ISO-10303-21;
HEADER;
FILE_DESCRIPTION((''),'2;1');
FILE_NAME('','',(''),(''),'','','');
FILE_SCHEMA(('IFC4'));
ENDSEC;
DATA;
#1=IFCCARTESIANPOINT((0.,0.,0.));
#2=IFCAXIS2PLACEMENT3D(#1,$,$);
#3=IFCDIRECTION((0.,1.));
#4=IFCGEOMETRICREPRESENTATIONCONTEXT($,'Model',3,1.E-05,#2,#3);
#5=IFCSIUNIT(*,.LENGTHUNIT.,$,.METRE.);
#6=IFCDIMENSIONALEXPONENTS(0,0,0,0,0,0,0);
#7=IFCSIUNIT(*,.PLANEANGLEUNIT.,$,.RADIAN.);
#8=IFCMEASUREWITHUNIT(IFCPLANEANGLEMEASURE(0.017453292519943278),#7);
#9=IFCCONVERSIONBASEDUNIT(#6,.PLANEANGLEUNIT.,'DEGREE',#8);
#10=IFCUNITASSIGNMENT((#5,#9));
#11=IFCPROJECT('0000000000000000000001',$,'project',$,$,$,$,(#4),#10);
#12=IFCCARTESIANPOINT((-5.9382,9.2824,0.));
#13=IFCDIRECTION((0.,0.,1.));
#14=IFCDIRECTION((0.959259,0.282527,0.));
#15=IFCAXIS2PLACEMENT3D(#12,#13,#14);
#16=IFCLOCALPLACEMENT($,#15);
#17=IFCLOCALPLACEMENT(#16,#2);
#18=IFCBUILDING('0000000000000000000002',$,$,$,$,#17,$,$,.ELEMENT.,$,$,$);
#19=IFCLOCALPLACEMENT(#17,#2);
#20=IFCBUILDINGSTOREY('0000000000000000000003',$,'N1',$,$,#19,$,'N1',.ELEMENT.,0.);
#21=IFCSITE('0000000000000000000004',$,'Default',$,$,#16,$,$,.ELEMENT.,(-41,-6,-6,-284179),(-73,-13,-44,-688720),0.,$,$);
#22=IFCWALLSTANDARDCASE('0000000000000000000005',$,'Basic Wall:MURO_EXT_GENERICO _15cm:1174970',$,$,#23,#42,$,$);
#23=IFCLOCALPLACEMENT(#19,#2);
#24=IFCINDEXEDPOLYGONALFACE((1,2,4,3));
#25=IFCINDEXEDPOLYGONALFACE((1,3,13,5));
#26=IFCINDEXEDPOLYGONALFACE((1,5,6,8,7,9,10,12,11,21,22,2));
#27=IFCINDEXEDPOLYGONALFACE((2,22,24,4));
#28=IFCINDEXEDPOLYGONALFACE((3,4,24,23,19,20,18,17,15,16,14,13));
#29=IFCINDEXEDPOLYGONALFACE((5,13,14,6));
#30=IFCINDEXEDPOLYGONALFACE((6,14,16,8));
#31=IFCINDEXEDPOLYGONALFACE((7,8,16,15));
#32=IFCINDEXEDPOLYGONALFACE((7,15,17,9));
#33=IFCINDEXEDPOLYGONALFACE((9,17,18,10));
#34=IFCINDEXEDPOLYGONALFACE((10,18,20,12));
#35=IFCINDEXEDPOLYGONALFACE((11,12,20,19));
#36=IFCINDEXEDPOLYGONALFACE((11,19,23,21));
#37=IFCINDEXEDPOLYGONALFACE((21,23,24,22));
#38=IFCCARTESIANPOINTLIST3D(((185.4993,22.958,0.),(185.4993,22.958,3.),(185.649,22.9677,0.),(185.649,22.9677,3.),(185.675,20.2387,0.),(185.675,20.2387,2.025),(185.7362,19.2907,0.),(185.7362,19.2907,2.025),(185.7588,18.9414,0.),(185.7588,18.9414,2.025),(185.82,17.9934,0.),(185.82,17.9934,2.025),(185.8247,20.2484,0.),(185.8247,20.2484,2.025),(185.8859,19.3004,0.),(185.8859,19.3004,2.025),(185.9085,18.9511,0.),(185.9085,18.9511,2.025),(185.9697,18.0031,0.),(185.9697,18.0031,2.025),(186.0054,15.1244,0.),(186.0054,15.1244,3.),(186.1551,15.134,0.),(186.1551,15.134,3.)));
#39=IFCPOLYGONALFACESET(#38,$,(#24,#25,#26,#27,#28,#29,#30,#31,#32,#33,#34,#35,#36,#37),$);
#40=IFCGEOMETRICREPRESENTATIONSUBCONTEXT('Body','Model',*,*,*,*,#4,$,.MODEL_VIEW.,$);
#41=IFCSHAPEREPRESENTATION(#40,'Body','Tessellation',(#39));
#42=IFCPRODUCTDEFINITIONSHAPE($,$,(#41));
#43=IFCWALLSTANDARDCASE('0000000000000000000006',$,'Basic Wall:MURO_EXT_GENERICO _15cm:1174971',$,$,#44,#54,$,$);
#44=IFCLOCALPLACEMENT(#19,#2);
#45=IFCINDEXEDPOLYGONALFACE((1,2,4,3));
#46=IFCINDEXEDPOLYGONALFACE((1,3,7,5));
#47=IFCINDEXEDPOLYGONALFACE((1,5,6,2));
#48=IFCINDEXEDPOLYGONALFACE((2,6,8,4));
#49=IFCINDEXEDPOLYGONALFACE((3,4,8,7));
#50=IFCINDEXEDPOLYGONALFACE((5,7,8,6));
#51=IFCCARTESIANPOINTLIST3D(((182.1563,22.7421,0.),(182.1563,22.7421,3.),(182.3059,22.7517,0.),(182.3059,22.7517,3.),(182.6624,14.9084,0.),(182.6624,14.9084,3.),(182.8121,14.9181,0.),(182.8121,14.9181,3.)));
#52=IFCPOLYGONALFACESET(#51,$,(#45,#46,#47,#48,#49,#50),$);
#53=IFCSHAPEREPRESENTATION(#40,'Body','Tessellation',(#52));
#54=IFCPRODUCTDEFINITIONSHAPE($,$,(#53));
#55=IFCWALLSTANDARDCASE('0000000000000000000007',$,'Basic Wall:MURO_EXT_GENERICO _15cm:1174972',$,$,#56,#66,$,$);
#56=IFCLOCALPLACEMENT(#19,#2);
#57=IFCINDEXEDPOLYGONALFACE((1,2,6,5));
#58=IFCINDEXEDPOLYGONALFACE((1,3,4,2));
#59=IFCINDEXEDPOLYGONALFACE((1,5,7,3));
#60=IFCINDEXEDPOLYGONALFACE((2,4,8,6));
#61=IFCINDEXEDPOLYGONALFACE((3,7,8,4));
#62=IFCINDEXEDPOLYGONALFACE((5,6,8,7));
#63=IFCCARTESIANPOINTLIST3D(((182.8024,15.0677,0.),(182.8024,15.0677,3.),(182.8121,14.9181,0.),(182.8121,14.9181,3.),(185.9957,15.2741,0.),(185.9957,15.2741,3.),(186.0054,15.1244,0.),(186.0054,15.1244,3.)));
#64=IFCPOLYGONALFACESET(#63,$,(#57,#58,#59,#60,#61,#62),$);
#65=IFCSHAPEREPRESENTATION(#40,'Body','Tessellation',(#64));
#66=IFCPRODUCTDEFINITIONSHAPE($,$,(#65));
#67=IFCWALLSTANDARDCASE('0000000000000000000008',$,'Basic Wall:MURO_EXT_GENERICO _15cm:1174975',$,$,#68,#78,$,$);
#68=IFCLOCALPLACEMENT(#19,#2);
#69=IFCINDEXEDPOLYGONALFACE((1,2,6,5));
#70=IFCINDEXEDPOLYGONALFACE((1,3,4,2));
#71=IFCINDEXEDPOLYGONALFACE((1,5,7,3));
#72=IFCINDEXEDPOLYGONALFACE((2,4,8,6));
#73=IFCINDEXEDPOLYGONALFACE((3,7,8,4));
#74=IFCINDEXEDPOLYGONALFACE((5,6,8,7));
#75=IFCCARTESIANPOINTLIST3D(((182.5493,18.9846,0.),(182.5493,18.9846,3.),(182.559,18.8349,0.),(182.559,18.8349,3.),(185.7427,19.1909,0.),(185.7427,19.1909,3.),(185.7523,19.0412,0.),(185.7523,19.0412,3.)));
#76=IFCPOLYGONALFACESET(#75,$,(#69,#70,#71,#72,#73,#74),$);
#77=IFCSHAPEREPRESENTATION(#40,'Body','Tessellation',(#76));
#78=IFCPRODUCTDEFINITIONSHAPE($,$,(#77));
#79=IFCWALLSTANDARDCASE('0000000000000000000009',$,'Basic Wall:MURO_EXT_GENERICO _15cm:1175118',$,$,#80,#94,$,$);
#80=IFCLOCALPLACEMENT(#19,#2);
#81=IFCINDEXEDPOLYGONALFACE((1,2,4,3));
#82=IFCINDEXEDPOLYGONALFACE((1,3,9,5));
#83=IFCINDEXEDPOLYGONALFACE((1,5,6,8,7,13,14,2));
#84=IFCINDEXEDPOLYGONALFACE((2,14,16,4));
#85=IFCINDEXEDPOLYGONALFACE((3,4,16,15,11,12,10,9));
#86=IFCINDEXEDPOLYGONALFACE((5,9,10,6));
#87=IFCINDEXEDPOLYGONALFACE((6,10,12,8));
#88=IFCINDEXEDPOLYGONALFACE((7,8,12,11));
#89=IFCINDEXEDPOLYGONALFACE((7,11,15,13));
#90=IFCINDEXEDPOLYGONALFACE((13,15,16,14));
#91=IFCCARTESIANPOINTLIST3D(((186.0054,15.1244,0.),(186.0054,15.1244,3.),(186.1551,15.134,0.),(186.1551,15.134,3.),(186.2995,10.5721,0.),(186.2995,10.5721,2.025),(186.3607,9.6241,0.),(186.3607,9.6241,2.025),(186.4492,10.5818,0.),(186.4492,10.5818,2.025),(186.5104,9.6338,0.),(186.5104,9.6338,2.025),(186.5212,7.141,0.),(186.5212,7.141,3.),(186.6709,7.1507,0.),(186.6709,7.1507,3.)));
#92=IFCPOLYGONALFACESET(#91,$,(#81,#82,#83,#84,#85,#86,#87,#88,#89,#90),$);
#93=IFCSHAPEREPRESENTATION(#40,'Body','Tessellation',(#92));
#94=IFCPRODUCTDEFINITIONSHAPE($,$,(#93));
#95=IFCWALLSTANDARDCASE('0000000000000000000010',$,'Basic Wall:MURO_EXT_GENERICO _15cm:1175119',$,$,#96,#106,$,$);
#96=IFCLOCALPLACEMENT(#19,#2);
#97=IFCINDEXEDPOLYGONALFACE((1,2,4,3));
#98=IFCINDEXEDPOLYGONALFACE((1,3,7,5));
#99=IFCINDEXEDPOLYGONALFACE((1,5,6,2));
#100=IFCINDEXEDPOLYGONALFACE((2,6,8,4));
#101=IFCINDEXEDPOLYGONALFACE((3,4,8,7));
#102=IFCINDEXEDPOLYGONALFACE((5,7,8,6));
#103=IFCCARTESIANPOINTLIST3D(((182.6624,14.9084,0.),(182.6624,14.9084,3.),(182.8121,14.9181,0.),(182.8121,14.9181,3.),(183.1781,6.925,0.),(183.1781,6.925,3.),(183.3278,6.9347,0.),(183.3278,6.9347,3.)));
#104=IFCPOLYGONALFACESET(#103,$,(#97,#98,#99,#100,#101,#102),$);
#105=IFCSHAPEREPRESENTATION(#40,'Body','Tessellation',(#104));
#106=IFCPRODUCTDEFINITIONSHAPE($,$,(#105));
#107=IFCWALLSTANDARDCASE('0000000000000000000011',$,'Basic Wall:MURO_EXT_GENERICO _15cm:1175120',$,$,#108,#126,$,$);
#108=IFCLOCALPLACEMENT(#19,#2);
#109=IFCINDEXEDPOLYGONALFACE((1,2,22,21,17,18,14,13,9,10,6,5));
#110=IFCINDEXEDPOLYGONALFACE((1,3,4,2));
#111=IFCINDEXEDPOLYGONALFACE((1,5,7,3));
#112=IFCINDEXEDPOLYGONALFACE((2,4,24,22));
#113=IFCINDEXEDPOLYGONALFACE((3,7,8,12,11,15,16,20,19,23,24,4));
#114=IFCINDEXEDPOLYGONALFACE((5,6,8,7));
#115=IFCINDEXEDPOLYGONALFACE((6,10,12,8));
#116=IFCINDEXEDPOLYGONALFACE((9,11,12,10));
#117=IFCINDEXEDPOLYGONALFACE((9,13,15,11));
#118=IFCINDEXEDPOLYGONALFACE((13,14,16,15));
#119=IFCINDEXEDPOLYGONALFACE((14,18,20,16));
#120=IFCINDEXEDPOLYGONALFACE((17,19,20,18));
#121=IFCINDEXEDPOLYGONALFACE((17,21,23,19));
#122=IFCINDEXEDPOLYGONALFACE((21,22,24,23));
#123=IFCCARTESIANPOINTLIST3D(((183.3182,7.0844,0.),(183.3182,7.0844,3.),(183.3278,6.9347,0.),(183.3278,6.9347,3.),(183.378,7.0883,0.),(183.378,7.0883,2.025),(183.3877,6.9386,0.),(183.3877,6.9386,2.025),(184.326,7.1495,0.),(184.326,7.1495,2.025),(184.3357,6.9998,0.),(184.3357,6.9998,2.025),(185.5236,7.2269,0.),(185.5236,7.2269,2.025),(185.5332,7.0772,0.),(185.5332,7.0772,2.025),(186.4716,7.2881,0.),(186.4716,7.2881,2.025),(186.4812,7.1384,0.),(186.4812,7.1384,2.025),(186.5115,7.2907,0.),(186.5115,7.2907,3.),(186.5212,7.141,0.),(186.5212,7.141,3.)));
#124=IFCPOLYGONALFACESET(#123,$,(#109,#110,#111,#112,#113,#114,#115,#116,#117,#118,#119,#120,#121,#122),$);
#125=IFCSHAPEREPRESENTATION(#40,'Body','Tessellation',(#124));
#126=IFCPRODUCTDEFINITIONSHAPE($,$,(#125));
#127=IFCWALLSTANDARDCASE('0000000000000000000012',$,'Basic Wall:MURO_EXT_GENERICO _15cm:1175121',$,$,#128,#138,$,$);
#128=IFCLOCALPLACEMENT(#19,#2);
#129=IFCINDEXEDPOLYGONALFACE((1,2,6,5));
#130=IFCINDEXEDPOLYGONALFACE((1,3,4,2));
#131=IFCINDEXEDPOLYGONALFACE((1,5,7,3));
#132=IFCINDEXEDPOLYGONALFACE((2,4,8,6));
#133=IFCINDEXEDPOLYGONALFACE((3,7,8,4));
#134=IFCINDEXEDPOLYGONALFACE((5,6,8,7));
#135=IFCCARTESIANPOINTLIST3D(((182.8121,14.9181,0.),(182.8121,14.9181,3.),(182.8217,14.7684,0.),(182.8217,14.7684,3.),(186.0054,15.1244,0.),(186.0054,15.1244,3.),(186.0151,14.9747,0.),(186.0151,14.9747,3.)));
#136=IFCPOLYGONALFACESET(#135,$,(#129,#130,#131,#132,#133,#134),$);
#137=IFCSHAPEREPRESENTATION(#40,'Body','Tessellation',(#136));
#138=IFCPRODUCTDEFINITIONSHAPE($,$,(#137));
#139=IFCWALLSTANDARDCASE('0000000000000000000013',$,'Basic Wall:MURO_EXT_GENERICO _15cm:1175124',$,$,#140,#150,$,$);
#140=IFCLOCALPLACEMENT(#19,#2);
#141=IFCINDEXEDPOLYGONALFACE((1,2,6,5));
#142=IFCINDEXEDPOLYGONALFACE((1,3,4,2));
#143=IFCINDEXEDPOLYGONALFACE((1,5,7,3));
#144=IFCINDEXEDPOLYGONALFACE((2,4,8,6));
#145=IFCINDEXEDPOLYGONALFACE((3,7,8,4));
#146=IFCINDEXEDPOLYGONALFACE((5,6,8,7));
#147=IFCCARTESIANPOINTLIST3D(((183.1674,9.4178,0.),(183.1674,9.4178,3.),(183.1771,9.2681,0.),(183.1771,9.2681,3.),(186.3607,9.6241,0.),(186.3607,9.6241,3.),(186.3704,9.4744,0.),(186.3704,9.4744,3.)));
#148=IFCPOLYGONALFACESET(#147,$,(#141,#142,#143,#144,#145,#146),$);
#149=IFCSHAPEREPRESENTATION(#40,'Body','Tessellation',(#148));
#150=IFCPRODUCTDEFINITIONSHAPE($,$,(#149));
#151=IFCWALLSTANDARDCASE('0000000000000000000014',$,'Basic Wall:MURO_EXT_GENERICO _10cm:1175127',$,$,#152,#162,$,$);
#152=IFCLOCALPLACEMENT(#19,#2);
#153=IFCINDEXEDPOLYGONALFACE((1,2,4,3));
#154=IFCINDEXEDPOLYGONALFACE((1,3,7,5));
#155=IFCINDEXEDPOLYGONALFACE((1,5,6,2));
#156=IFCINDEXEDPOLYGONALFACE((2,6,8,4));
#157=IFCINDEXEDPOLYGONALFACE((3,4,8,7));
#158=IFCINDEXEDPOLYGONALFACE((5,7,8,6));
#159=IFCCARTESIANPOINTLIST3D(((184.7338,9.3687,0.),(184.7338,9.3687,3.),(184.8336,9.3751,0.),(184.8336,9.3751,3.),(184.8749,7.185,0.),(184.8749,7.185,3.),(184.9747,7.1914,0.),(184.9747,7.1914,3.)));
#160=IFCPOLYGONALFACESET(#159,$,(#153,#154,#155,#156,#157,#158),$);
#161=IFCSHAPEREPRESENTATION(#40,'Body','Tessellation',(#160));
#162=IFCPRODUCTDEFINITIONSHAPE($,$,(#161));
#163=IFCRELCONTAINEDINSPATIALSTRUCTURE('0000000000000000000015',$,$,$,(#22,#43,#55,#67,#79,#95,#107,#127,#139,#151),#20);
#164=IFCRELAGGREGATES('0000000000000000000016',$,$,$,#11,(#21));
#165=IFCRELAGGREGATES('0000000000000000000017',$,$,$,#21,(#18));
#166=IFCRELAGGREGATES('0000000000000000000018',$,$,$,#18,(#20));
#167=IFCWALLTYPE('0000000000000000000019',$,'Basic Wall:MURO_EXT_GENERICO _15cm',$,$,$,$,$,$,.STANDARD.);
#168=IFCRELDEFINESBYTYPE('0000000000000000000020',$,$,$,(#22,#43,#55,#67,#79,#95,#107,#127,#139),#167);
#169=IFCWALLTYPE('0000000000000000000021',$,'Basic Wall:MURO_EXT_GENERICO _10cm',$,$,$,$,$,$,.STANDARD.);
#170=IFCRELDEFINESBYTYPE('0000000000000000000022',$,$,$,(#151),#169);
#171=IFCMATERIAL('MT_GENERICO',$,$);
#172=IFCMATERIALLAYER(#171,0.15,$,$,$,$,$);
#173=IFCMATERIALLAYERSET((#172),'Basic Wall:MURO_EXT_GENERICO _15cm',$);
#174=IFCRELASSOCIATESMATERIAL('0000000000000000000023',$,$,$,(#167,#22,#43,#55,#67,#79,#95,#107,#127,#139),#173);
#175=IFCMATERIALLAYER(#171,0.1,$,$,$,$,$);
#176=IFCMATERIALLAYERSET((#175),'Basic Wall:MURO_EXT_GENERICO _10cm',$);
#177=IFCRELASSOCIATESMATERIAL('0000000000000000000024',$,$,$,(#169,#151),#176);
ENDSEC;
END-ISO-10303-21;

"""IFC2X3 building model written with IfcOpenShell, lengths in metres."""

from ifc_helpers import new_model, entity, si_unit, converted_unit, direction, frame, frame_2d, origin, place, context, subcontext, project, spatial, rectangle, extrude, material, layer, layer_set, layer_usage, type_object, element, save


model = new_model("IFC2X3")

# Units and contexts
model_context = context("Model", 3, precision=1e-05, world=origin(), true_north=direction((0.0, 1.0)))
body_context = subcontext(model_context, "Body", "Model", "MODEL_VIEW")
ifc_project = project(units=[si_unit("LENGTHUNIT", "METRE"), converted_unit("PLANEANGLEUNIT", "DEGREE", entity("IfcPlaneAngleMeasure", 0.017453292519943278), si_unit("PLANEANGLEUNIT", "RADIAN"), dimensions=[0, 0, 0, 0, 0, 0, 0])], contexts=[model_context])

# Site, building, storey
site_placement = place(None, frame((-5.9382, 9.2824, 0.0), z_axis=(0.0, 0.0, 1.0), x_axis=(0.959259, 0.282527, 0.0)))
site = spatial("IfcSite", under=ifc_project, at=site_placement, Name="Default", CompositionType="ELEMENT", RefLatitude=(-41, -6, -6, -284179), RefLongitude=(-73, -13, -44, -688720), RefElevation=0.0)
building_placement = place(site_placement, origin())
building = spatial("IfcBuilding", under=site, at=building_placement, CompositionType="ELEMENT")
storey_placement = place(building_placement, origin())
storey = spatial("IfcBuildingStorey", under=building, at=storey_placement, Name="N1", LongName="N1", CompositionType="ELEMENT", Elevation=0.0)

# Shared definitions
ifc_material_1 = material(Name="MT_GENERICO")

# Shared definitions
ifc_layer_1 = layer(ifc_material_1, 0.15)
ifc_layer_set_1 = layer_set([ifc_layer_1], Name="Basic Wall:MURO_EXT_GENERICO _15cm")
wall_type_1 = type_object("IfcWallType", Name="Basic Wall:MURO_EXT_GENERICO _15cm", PredefinedType="STANDARD", material=ifc_layer_set_1)

# Wall, openings
ifc_layer_usage_1 = layer_usage(ifc_layer_set_1, "AXIS2", "POSITIVE", -0.075)
wall_1_placement = place(storey_placement, frame((185.5741, 22.9629, 0.0), z_axis=(0.0, 0.0, 1.0), x_axis=(0.064471, -0.99792, 0.0)))
wall_1 = element("IfcWallStandardCase", 1, at=wall_1_placement, inside=storey, type_object=wall_type_1, material=ifc_layer_usage_1, Name="Basic Wall:MURO_EXT_GENERICO _15cm:1174970", context=body_context, shape_type="SweptSolid", body=[
    extrude(rectangle(XDim=7.85, YDim=0.15, at=frame_2d((3.925, 0.0), x_axis=(1.0, 0.0))), origin(), (0.0, 0.0, 1.0), 3.0),
])
opening_1_placement = place(wall_1_placement, frame((3.675, 0.075, 0.0)))
element("IfcOpeningElement", 2, at=opening_1_placement, cuts=wall_1, ObjectType="Opening", context=body_context, shape_type="SweptSolid", body=[
    extrude(rectangle(XDim=2.025, YDim=0.95, at=frame_2d((1.0125, 0.475), x_axis=(1.0, 0.0))), frame((0.0, 0.0, 0.0), z_axis=(0.0, -1.0, 0.0), x_axis=(0.0, 0.0, 1.0)), (0.0, 0.0, 1.0), 0.15),
])
opening_2_placement = place(wall_1_placement, frame((4.975, 0.075, 0.0)))
element("IfcOpeningElement", 3, at=opening_2_placement, cuts=wall_1, ObjectType="Opening", context=body_context, shape_type="SweptSolid", body=[
    extrude(rectangle(XDim=2.025, YDim=0.95, at=frame_2d((1.0125, 0.475), x_axis=(1.0, 0.0))), frame((0.0, 0.0, 0.0), z_axis=(0.0, -1.0, 0.0), x_axis=(0.0, 0.0, 1.0)), (0.0, 0.0, 1.0), 0.15),
])

# Walls
ifc_layer_usage_2 = layer_usage(ifc_layer_set_1, "AXIS2", "POSITIVE", -0.075)
wall_2_placement = place(storey_placement, frame((182.7372, 14.9132, 0.0), z_axis=(0.0, 0.0, 1.0), x_axis=(-0.064471, 0.99792, 0.0)))
element("IfcWallStandardCase", 4, at=wall_2_placement, inside=storey, type_object=wall_type_1, material=ifc_layer_usage_2, Name="Basic Wall:MURO_EXT_GENERICO _15cm:1174971", context=body_context, shape_type="SweptSolid", body=[
    extrude(rectangle(XDim=7.85, YDim=0.15, at=frame_2d((3.925, 0.0), x_axis=(-1.0, 0.0))), origin(), (0.0, 0.0, 1.0), 3.0),
])
ifc_layer_usage_3 = layer_usage(ifc_layer_set_1, "AXIS2", "POSITIVE", -0.075)
wall_3_placement = place(storey_placement, frame((186.0006, 15.1992, 0.0), z_axis=(0.0, 0.0, 1.0), x_axis=(-0.99792, -0.064471, 0.0)))
element("IfcWallStandardCase", 5, at=wall_3_placement, inside=storey, type_object=wall_type_1, material=ifc_layer_usage_3, Name="Basic Wall:MURO_EXT_GENERICO _15cm:1174972", context=body_context, shape_type="SweptSolid", body=[
    extrude(rectangle(XDim=3.2, YDim=0.15, at=frame_2d((1.6, 0.0), x_axis=(-1.0, 0.0))), origin(), (0.0, 0.0, 1.0), 3.0),
])
ifc_layer_usage_4 = layer_usage(ifc_layer_set_1, "AXIS2", "POSITIVE", -0.075)
wall_4_placement = place(storey_placement, frame((185.7475, 19.116, 0.0), z_axis=(0.0, 0.0, 1.0), x_axis=(-0.99792, -0.064471, 0.0)))
element("IfcWallStandardCase", 6, at=wall_4_placement, inside=storey, type_object=wall_type_1, material=ifc_layer_usage_4, Name="Basic Wall:MURO_EXT_GENERICO _15cm:1174975", context=body_context, shape_type="SweptSolid", body=[
    extrude(rectangle(XDim=3.2, YDim=0.15, at=frame_2d((1.6, 0.0), x_axis=(-1.0, 0.0))), origin(), (0.0, 0.0, 1.0), 3.0),
])

# Wall, opening
ifc_layer_usage_5 = layer_usage(ifc_layer_set_1, "AXIS2", "POSITIVE", -0.075)
wall_5_placement = place(storey_placement, frame((186.0802, 15.1292, 0.0), z_axis=(0.0, 0.0, 1.0), x_axis=(0.064471, -0.99792, 0.0)))
wall_5 = element("IfcWallStandardCase", 7, at=wall_5_placement, inside=storey, type_object=wall_type_1, material=ifc_layer_usage_5, Name="Basic Wall:MURO_EXT_GENERICO _15cm:1175118", context=body_context, shape_type="SweptSolid", body=[
    extrude(rectangle(XDim=8.0, YDim=0.15, at=frame_2d((4.0, 0.0), x_axis=(-1.0, 0.0))), origin(), (0.0, 0.0, 1.0), 3.0),
])
opening_3_placement = place(wall_5_placement, frame((5.5117, 0.075, 0.0)))
element("IfcOpeningElement", 8, at=opening_3_placement, cuts=wall_5, ObjectType="Opening", context=body_context, shape_type="SweptSolid", body=[
    extrude(rectangle(XDim=2.025, YDim=0.95, at=frame_2d((1.0125, 0.475), x_axis=(1.0, 0.0))), frame((0.0, 0.0, 0.0), z_axis=(0.0, -1.0, 0.0), x_axis=(0.0, 0.0, 1.0)), (0.0, 0.0, 1.0), 0.15),
])

# Wall
ifc_layer_usage_6 = layer_usage(ifc_layer_set_1, "AXIS2", "POSITIVE", -0.075)
wall_6_placement = place(storey_placement, frame((183.253, 6.9299, 0.0), z_axis=(0.0, 0.0, 1.0), x_axis=(-0.064471, 0.99792, 0.0)))
element("IfcWallStandardCase", 9, at=wall_6_placement, inside=storey, type_object=wall_type_1, material=ifc_layer_usage_6, Name="Basic Wall:MURO_EXT_GENERICO _15cm:1175119", context=body_context, shape_type="SweptSolid", body=[
    extrude(rectangle(XDim=8.0, YDim=0.15, at=frame_2d((4.0, 0.0), x_axis=(-1.0, 0.0))), origin(), (0.0, 0.0, 1.0), 3.0),
])

# Wall, openings
ifc_layer_usage_7 = layer_usage(ifc_layer_set_1, "AXIS2", "POSITIVE", -0.075)
wall_7_placement = place(storey_placement, frame((186.5163, 7.2159, 0.0), z_axis=(0.0, 0.0, 1.0), x_axis=(-0.99792, -0.064471, 0.0)))
wall_7 = element("IfcWallStandardCase", 10, at=wall_7_placement, inside=storey, type_object=wall_type_1, material=ifc_layer_usage_7, Name="Basic Wall:MURO_EXT_GENERICO _15cm:1175120", context=body_context, shape_type="SweptSolid", body=[
    extrude(rectangle(XDim=3.2, YDim=0.15, at=frame_2d((1.6, 0.0), x_axis=(1.0, 0.0))), origin(), (0.0, 0.0, 1.0), 3.0),
])
opening_4_placement = place(wall_7_placement, frame((0.99, 0.075, 0.0)))
element("IfcOpeningElement", 11, at=opening_4_placement, cuts=wall_7, ObjectType="Opening", context=body_context, shape_type="SweptSolid", body=[
    extrude(rectangle(XDim=2.025, YDim=0.95, at=frame_2d((1.0125, 0.475), x_axis=(1.0, 0.0))), frame((0.0, 0.0, 0.0), z_axis=(0.0, -1.0, 0.0), x_axis=(0.0, 0.0, 1.0)), (0.0, 0.0, 1.0), 0.15),
])
opening_5_placement = place(wall_7_placement, frame((3.14, 0.075, 0.0)))
element("IfcOpeningElement", 12, at=opening_5_placement, cuts=wall_7, ObjectType="Opening", context=body_context, shape_type="SweptSolid", body=[
    extrude(rectangle(XDim=2.025, YDim=0.95, at=frame_2d((1.0125, 0.475), x_axis=(1.0, 0.0))), frame((0.0, 0.0, 0.0), z_axis=(0.0, -1.0, 0.0), x_axis=(0.0, 0.0, 1.0)), (0.0, 0.0, 1.0), 0.15),
])

# Walls
ifc_layer_usage_8 = layer_usage(ifc_layer_set_1, "AXIS2", "POSITIVE", -0.075)
wall_8_placement = place(storey_placement, frame((182.8169, 14.8432, 0.0), z_axis=(0.0, 0.0, 1.0), x_axis=(0.99792, 0.064471, 0.0)))
element("IfcWallStandardCase", 13, at=wall_8_placement, inside=storey, type_object=wall_type_1, material=ifc_layer_usage_8, Name="Basic Wall:MURO_EXT_GENERICO _15cm:1175121", context=body_context, shape_type="SweptSolid", body=[
    extrude(rectangle(XDim=3.2, YDim=0.15, at=frame_2d((1.6, 0.0), x_axis=(-1.0, 0.0))), origin(), (0.0, 0.0, 1.0), 3.0),
])
ifc_layer_usage_9 = layer_usage(ifc_layer_set_1, "AXIS2", "POSITIVE", -0.075)
wall_9_placement = place(storey_placement, frame((186.3656, 9.5493, 0.0), z_axis=(0.0, 0.0, 1.0), x_axis=(-0.99792, -0.064471, 0.0)))
element("IfcWallStandardCase", 14, at=wall_9_placement, inside=storey, type_object=wall_type_1, material=ifc_layer_usage_9, Name="Basic Wall:MURO_EXT_GENERICO _15cm:1175124", context=body_context, shape_type="SweptSolid", body=[
    extrude(rectangle(XDim=3.2, YDim=0.15, at=frame_2d((1.6, 0.0), x_axis=(-1.0, 0.0))), origin(), (0.0, 0.0, 1.0), 3.0),
])
ifc_layer_2 = layer(ifc_material_1, 0.1)
ifc_layer_set_2 = layer_set([ifc_layer_2], Name="Basic Wall:MURO_EXT_GENERICO _10cm")
ifc_layer_usage_10 = layer_usage(ifc_layer_set_2, "AXIS2", "POSITIVE", -0.05)
wall_type_2 = type_object("IfcWallType", Name="Basic Wall:MURO_EXT_GENERICO _10cm", PredefinedType="STANDARD", material=ifc_layer_set_2)
wall_10_placement = place(storey_placement, frame((184.9248, 7.1882, 0.0), z_axis=(0.0, 0.0, 1.0), x_axis=(-0.064471, 0.99792, 0.0)))
element("IfcWallStandardCase", 15, at=wall_10_placement, inside=storey, type_object=wall_type_2, material=ifc_layer_usage_10, Name="Basic Wall:MURO_EXT_GENERICO _10cm:1175127", context=body_context, shape_type="SweptSolid", body=[
    extrude(rectangle(XDim=2.1883, YDim=0.1, at=frame_2d((1.0941, 0.0), x_axis=(-1.0, 0.0))), origin(), (0.0, 0.0, 1.0), 3.0),
])

save(model, "model.ifc")
